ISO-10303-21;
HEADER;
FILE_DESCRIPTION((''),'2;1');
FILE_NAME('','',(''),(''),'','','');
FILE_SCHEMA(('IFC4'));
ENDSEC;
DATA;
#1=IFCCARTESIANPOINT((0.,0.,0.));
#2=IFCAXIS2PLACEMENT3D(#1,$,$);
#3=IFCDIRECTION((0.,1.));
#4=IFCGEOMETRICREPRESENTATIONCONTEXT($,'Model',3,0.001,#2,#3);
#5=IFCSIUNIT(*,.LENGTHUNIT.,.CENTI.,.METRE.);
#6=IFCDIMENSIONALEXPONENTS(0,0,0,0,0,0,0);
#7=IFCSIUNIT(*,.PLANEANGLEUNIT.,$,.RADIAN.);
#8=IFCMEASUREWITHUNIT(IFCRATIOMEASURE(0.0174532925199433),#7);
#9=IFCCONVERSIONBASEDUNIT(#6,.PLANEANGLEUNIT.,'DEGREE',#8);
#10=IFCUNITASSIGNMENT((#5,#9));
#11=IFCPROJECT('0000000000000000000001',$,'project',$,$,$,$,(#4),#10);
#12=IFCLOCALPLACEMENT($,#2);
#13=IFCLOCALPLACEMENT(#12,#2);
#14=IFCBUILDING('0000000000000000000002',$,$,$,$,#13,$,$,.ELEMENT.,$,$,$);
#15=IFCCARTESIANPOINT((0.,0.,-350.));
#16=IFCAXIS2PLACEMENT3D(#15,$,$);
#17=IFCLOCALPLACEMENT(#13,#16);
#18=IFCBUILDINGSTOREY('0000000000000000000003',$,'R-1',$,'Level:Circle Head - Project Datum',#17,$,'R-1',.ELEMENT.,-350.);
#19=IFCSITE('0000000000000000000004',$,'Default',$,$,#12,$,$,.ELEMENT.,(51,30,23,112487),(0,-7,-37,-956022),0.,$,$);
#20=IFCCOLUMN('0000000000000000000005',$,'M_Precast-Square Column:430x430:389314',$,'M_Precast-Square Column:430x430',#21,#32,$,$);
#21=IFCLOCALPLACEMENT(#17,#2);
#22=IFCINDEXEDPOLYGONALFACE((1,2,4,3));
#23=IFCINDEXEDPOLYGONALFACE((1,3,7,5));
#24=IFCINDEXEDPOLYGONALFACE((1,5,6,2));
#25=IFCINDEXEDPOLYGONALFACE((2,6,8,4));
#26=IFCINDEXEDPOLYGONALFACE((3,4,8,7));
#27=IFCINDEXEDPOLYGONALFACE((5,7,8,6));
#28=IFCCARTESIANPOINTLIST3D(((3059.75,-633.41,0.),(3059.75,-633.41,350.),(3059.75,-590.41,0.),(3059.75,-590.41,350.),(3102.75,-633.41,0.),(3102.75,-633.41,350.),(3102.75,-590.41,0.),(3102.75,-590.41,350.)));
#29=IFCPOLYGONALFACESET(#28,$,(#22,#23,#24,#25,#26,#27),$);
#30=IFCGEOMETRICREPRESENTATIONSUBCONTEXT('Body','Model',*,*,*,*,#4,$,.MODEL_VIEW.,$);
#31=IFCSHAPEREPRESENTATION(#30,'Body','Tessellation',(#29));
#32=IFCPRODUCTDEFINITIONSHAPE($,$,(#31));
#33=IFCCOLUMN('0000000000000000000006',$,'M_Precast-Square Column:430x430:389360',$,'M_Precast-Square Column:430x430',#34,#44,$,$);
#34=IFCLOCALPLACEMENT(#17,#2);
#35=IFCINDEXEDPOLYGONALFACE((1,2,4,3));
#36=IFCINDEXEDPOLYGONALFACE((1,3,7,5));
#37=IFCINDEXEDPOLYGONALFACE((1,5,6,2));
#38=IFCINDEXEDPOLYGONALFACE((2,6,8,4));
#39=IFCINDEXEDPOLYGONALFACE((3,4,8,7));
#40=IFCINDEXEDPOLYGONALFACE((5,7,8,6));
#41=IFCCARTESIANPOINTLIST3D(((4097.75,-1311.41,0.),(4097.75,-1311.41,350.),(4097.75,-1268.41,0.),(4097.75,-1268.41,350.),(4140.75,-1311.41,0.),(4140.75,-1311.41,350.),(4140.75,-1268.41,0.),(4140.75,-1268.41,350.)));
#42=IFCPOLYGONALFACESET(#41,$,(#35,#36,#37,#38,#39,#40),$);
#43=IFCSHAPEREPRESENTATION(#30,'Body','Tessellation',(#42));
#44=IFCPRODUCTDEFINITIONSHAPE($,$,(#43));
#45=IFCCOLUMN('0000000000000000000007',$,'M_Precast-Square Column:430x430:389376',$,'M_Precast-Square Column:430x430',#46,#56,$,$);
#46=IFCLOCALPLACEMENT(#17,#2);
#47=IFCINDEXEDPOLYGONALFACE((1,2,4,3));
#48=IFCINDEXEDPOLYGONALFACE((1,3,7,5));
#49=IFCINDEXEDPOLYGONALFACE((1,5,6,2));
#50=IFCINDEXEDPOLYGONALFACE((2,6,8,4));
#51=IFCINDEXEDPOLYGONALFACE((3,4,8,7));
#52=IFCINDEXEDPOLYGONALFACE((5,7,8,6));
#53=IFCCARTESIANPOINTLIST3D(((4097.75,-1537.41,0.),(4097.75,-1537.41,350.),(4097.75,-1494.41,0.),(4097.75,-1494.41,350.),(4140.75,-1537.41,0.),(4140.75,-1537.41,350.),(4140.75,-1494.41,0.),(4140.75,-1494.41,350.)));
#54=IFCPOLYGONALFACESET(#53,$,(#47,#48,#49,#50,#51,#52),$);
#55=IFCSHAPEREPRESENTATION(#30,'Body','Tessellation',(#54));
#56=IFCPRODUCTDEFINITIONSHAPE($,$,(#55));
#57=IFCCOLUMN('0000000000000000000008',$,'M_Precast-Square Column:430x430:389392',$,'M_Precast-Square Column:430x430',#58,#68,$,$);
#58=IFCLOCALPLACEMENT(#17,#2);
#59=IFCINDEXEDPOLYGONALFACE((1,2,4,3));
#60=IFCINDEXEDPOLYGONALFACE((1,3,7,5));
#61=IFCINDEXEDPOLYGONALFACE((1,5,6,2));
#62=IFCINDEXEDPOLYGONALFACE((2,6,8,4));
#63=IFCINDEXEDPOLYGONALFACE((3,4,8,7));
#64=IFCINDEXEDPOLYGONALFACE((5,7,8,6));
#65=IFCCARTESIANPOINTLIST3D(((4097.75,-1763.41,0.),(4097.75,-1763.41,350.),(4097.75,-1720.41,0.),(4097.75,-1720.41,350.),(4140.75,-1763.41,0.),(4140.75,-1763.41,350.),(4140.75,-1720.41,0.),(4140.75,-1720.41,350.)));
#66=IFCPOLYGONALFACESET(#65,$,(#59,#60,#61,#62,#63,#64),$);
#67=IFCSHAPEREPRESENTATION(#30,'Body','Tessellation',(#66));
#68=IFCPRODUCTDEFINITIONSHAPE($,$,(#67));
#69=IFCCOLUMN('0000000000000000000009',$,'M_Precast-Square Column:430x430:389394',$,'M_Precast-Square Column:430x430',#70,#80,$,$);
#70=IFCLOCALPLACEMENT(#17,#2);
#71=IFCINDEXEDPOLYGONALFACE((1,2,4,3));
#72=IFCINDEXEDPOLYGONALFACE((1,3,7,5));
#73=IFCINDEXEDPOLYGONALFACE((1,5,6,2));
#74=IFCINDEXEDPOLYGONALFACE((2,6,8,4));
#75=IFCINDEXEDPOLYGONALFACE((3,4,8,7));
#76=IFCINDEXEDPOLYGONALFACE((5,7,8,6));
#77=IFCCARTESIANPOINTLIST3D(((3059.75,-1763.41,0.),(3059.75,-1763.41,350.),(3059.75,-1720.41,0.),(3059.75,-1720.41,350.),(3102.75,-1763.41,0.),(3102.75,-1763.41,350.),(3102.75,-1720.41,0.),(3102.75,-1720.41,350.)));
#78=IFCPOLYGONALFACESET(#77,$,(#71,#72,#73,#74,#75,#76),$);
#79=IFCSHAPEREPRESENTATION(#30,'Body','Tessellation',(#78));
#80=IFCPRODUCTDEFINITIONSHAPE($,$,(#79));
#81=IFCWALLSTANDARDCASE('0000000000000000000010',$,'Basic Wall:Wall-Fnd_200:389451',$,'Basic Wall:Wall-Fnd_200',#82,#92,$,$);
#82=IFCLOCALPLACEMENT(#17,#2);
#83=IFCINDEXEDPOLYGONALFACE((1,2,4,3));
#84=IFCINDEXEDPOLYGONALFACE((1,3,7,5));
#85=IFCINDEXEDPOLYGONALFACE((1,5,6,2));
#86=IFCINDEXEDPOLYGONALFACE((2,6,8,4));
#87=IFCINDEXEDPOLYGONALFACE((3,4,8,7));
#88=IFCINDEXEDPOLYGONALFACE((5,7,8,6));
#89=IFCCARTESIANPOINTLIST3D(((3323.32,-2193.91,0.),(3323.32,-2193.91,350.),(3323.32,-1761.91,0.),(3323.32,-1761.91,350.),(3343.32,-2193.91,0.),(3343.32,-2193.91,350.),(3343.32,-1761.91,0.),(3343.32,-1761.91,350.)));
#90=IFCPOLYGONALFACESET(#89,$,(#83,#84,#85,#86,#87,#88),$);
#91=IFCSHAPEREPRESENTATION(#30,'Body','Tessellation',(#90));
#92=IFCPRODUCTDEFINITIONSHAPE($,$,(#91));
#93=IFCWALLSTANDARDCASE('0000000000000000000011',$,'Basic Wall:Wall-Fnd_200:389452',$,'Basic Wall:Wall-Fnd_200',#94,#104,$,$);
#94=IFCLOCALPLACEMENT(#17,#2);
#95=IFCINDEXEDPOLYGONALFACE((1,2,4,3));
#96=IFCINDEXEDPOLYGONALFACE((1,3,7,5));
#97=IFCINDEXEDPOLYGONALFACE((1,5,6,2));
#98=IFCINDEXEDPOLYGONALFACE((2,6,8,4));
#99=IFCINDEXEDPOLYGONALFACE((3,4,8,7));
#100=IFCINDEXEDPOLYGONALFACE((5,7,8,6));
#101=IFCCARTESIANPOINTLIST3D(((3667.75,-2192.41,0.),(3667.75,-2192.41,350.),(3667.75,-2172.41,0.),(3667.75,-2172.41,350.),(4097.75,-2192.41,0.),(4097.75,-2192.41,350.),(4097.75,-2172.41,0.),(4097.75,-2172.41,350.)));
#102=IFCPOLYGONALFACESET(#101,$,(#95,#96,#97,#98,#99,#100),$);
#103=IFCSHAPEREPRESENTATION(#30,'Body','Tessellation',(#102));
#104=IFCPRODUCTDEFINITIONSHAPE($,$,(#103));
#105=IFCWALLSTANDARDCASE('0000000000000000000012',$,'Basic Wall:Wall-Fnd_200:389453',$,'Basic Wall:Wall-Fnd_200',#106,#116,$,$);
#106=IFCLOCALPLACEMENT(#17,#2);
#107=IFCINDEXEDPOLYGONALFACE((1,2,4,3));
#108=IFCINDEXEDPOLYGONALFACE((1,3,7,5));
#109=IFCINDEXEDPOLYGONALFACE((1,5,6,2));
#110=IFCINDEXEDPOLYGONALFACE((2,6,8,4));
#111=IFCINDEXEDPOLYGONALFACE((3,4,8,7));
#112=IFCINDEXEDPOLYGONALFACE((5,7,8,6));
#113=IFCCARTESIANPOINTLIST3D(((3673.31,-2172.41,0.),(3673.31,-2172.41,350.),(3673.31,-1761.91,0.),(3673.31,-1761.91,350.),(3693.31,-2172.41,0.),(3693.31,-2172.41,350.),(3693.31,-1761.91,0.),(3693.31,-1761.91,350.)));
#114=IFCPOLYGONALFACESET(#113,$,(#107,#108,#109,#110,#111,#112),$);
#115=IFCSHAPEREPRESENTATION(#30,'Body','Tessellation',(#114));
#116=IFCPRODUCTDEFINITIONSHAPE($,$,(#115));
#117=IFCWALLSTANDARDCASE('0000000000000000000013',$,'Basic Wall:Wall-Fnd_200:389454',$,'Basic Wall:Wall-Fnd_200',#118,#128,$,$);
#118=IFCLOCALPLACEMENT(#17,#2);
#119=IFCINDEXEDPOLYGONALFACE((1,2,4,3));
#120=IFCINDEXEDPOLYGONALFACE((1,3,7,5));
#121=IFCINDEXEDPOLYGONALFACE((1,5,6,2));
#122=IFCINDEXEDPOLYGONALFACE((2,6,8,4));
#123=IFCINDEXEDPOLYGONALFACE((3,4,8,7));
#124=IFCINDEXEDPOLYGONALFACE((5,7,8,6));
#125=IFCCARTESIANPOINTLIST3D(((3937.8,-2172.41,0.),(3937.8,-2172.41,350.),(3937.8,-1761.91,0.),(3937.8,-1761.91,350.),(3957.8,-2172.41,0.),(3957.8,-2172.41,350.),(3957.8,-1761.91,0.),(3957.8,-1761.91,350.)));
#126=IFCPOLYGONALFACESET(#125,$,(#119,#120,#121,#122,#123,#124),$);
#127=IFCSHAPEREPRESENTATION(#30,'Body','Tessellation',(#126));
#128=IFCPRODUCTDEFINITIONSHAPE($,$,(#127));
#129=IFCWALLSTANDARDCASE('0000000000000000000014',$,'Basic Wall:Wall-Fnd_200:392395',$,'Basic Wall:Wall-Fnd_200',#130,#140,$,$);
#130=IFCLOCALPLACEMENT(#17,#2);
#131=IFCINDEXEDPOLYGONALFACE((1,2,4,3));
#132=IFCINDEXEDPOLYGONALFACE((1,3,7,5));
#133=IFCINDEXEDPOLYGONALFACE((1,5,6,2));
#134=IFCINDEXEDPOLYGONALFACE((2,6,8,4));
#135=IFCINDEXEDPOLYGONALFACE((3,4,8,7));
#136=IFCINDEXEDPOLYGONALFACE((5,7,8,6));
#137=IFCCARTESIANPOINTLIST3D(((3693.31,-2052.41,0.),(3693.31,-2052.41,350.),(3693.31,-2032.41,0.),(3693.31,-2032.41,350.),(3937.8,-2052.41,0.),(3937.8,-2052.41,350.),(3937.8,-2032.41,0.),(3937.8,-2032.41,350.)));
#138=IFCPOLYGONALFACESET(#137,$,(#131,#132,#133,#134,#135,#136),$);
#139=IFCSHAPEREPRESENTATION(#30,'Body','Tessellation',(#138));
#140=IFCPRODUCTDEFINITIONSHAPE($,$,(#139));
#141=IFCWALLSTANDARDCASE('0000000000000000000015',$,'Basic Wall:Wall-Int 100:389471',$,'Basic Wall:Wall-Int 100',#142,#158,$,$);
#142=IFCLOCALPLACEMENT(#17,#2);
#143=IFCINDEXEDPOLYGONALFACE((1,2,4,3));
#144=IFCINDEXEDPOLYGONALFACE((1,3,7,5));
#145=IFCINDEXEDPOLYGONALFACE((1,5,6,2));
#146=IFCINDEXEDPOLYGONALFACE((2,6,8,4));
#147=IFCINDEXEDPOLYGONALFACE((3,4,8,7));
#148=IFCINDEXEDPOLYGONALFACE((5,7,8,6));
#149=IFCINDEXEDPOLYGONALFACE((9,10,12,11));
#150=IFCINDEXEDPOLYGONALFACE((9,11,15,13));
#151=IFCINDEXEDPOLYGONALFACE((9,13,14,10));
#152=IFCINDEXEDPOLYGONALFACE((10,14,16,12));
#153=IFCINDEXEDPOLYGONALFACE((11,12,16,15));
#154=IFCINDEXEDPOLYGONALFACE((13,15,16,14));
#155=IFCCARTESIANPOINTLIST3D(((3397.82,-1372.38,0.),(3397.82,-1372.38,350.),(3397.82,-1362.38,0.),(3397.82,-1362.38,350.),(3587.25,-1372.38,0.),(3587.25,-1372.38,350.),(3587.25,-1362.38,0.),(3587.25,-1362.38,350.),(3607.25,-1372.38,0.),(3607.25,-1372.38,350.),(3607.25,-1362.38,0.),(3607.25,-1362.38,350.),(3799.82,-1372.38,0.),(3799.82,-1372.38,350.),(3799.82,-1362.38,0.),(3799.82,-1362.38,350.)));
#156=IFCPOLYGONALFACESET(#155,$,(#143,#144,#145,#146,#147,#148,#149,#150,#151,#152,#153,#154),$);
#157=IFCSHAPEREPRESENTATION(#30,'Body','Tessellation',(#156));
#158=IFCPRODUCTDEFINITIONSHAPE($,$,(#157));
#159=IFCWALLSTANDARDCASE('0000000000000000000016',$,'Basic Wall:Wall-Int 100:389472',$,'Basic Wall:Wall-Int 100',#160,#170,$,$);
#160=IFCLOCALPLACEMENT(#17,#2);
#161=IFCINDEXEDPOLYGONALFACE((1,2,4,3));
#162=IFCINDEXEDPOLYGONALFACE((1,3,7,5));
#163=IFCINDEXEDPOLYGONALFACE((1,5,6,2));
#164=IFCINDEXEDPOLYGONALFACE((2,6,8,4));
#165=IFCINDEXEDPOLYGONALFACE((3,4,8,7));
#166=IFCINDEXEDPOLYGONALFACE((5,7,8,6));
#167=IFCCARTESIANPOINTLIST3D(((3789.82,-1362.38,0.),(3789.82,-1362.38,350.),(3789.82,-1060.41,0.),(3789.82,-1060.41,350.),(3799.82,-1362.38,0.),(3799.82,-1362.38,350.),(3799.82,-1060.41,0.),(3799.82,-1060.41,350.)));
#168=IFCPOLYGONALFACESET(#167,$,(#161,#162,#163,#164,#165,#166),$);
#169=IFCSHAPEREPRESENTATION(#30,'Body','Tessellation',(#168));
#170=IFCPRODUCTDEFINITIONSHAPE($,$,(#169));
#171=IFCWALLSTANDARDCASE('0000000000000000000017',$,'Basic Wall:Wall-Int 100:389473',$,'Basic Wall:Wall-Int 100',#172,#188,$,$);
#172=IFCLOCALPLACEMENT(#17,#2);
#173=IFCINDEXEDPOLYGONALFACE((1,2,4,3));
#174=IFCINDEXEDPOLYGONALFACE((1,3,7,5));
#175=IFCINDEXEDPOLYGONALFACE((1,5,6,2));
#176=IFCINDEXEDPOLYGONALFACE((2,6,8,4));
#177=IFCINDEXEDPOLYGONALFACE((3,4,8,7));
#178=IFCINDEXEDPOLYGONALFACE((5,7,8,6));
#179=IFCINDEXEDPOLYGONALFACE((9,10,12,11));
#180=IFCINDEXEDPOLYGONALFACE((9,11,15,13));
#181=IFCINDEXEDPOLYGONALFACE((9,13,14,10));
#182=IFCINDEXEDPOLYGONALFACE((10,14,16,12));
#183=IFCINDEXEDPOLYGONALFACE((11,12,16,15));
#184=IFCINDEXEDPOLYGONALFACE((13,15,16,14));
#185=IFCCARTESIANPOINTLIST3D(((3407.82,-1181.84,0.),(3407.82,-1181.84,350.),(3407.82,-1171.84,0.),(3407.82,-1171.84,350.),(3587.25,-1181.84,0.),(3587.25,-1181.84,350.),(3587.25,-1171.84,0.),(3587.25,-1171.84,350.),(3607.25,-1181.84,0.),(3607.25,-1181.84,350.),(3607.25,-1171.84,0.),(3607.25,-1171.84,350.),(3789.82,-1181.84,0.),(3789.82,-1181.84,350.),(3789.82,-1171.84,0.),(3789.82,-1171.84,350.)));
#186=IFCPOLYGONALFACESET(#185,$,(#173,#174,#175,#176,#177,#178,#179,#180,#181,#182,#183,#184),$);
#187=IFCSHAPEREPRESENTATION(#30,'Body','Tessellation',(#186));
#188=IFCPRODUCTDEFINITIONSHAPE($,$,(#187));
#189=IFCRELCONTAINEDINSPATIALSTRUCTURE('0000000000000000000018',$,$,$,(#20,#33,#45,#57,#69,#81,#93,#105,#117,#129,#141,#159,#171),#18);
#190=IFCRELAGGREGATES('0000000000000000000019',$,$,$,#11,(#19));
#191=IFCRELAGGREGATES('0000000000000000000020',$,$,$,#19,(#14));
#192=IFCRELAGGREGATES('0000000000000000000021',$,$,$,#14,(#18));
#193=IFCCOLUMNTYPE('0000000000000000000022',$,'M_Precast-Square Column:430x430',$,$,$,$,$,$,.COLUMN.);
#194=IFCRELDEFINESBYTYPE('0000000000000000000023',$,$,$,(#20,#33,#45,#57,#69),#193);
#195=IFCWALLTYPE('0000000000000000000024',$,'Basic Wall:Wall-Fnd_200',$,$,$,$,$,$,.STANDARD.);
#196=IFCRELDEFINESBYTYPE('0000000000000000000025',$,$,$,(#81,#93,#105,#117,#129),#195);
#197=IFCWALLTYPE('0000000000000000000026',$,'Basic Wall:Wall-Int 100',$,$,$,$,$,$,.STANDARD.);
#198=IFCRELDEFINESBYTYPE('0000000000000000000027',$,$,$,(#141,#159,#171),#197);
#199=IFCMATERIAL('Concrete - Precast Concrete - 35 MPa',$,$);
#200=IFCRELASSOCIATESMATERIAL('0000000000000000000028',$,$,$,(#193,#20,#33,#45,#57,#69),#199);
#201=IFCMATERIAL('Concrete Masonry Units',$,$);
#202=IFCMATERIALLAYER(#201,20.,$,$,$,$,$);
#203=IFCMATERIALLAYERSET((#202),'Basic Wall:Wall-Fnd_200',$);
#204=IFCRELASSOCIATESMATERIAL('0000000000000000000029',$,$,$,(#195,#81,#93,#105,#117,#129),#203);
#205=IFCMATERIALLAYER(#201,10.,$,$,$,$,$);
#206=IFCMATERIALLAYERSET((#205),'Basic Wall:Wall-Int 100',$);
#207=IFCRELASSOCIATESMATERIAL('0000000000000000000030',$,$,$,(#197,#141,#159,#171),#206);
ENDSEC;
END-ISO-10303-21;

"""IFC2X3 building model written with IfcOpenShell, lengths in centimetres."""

from ifc_helpers import new_model, entity, si_unit, converted_unit, direction, frame, frame_2d, origin, origin_2d_with_axis, place, context, subcontext, project, spatial, rectangle, extrude, source, transform, mapped, material, layer, layer_set, layer_usage, type_object, type_shapes, element, save


model = new_model("IFC2X3")

# Units and contexts
model_context = context("Model", 3, precision=0.001, world=origin(), true_north=direction((0.0, 1.0)))
body_context = subcontext(model_context, "Body", "Model", "MODEL_VIEW")
ifc_project = project(units=[si_unit("LENGTHUNIT", "METRE", prefix="CENTI"), converted_unit("PLANEANGLEUNIT", "DEGREE", entity("IfcRatioMeasure", 0.0174532925199433), si_unit("PLANEANGLEUNIT", "RADIAN"), dimensions=[0, 0, 0, 0, 0, 0, 0])], contexts=[model_context])

# Site, building, storey
site_placement = place(None, origin())
site = spatial("IfcSite", under=ifc_project, at=site_placement, Name="Default", CompositionType="ELEMENT", RefLatitude=(51, 30, 23, 112487), RefLongitude=(0, -7, -37, -956022), RefElevation=0.0)
building_placement = place(site_placement, origin())
building = spatial("IfcBuilding", under=site, at=building_placement, CompositionType="ELEMENT")
storey_placement = place(building_placement, frame((0.0, 0.0, -350.0)))
storey = spatial("IfcBuildingStorey", under=building, at=storey_placement, Name="R-1", ObjectType="Level:Circle Head - Project Datum", LongName="R-1", CompositionType="ELEMENT", Elevation=-350.0)

# Columns
ifc_material_1 = material(Name="Concrete - Precast Concrete - 35 MPa")
column_type_1 = type_object("IfcColumnType", Name="M_Precast-Square Column:430x430", PredefinedType="COLUMN", material=ifc_material_1)
shared_shape_1 = source(origin(), body_context, "Body", "SweptSolid", [
    extrude(rectangle(XDim=43.0, YDim=43.0, at=origin_2d_with_axis()), frame((0.0, 0.0, -350.0), z_axis=(0.0, 0.0, 1.0), x_axis=(0.0, -1.0, 0.0)), (0.0, 0.0, 1.0), 350.0),
])
type_shapes(column_type_1, [shared_shape_1])
for number, where, name in (
    (1, (3081.25, -611.91, 350.0), "M_Precast-Square Column:430x430:389314"),
    (2, (4119.25, -1289.91, 350.0), "M_Precast-Square Column:430x430:389360"),
    (3, (4119.25, -1515.91, 350.0), "M_Precast-Square Column:430x430:389376"),
    (4, (4119.25, -1741.91, 350.0), "M_Precast-Square Column:430x430:389392"),
    (5, (3081.25, -1741.91, 350.0), "M_Precast-Square Column:430x430:389394"),
):
    element("IfcColumn", number, at=place(storey_placement, frame(where)), inside=storey, type_object=column_type_1, material=ifc_material_1, Name=name, ObjectType="M_Precast-Square Column:430x430", context=body_context, shape_type="MappedRepresentation", body=[
        mapped(shared_shape_1, transform((0.0, 0.0, 0.0), scale=1.0)),
    ])

# Walls
ifc_material_2 = material(Name="Concrete Masonry Units")
ifc_layer_1 = layer(ifc_material_2, 20.0)
ifc_layer_set_1 = layer_set([ifc_layer_1], Name="Basic Wall:Wall-Fnd_200")
ifc_layer_usage_1 = layer_usage(ifc_layer_set_1, "AXIS2", "POSITIVE", -10.0)
wall_type_1 = type_object("IfcWallType", Name="Basic Wall:Wall-Fnd_200", PredefinedType="STANDARD", material=ifc_layer_set_1)
wall_1_placement = place(storey_placement, frame((3333.32, -2193.91, 0.0), z_axis=(0.0, 0.0, 1.0), x_axis=(0.0, 1.0, 0.0)))
element("IfcWallStandardCase", 6, at=wall_1_placement, inside=storey, type_object=wall_type_1, material=ifc_layer_usage_1, Name="Basic Wall:Wall-Fnd_200:389451", ObjectType="Basic Wall:Wall-Fnd_200", context=body_context, shape_type="SweptSolid", body=[
    extrude(rectangle(XDim=432.0, YDim=20.0, at=frame_2d((216.0, 0.0), x_axis=(-1.0, 0.0))), origin(), (0.0, 0.0, 1.0), 350.0),
])
ifc_layer_usage_2 = layer_usage(ifc_layer_set_1, "AXIS2", "POSITIVE", -10.0)
wall_2_placement = place(storey_placement, frame((4097.75, -2182.41, 0.0), z_axis=(0.0, 0.0, 1.0), x_axis=(-1.0, 0.0, 0.0)))
element("IfcWallStandardCase", 7, at=wall_2_placement, inside=storey, type_object=wall_type_1, material=ifc_layer_usage_2, Name="Basic Wall:Wall-Fnd_200:389452", ObjectType="Basic Wall:Wall-Fnd_200", context=body_context, shape_type="SweptSolid", body=[
    extrude(rectangle(XDim=430.0, YDim=20.0, at=frame_2d((215.0, 0.0), x_axis=(-1.0, 0.0))), origin(), (0.0, 0.0, 1.0), 350.0),
])
ifc_layer_usage_3 = layer_usage(ifc_layer_set_1, "AXIS2", "NEGATIVE", 10.0)
wall_3_placement = place(storey_placement, frame((3683.31, -1761.91, 0.0), z_axis=(0.0, 0.0, 1.0), x_axis=(0.0, -1.0, 0.0)))
element("IfcWallStandardCase", 8, at=wall_3_placement, inside=storey, type_object=wall_type_1, material=ifc_layer_usage_3, Name="Basic Wall:Wall-Fnd_200:389453", ObjectType="Basic Wall:Wall-Fnd_200", context=body_context, shape_type="SweptSolid", body=[
    extrude(rectangle(XDim=410.5, YDim=20.0, at=frame_2d((205.25, 0.0), x_axis=(-1.0, 0.0))), origin(), (0.0, 0.0, 1.0), 350.0),
])
ifc_layer_usage_4 = layer_usage(ifc_layer_set_1, "AXIS2", "NEGATIVE", 10.0)
wall_4_placement = place(storey_placement, frame((3947.8, -1761.91, 0.0), z_axis=(0.0, 0.0, 1.0), x_axis=(0.0, -1.0, 0.0)))
element("IfcWallStandardCase", 9, at=wall_4_placement, inside=storey, type_object=wall_type_1, material=ifc_layer_usage_4, Name="Basic Wall:Wall-Fnd_200:389454", ObjectType="Basic Wall:Wall-Fnd_200", context=body_context, shape_type="SweptSolid", body=[
    extrude(rectangle(XDim=410.5, YDim=20.0, at=frame_2d((205.25, 0.0), x_axis=(-1.0, 0.0))), origin(), (0.0, 0.0, 1.0), 350.0),
])
ifc_layer_usage_5 = layer_usage(ifc_layer_set_1, "AXIS2", "POSITIVE", -10.0)
wall_5_placement = place(storey_placement, frame((3937.8, -2042.41, 0.0), z_axis=(0.0, 0.0, 1.0), x_axis=(-1.0, 0.0, 0.0)))
element("IfcWallStandardCase", 10, at=wall_5_placement, inside=storey, type_object=wall_type_1, material=ifc_layer_usage_5, Name="Basic Wall:Wall-Fnd_200:392395", ObjectType="Basic Wall:Wall-Fnd_200", context=body_context, shape_type="SweptSolid", body=[
    extrude(rectangle(XDim=244.49, YDim=20.0, at=frame_2d((122.25, 0.0), x_axis=(-1.0, 0.0))), origin(), (0.0, 0.0, 1.0), 350.0),
])

# Wall, opening
ifc_layer_2 = layer(ifc_material_2, 10.0)
ifc_layer_set_2 = layer_set([ifc_layer_2], Name="Basic Wall:Wall-Int 100")
ifc_layer_usage_6 = layer_usage(ifc_layer_set_2, "AXIS2", "POSITIVE", -5.0)
wall_type_2 = type_object("IfcWallType", Name="Basic Wall:Wall-Int 100", PredefinedType="STANDARD", material=ifc_layer_set_2)
wall_6_placement = place(storey_placement, frame((3397.82, -1367.38, 0.0)))
wall_6 = element("IfcWallStandardCase", 11, at=wall_6_placement, inside=storey, type_object=wall_type_2, material=ifc_layer_usage_6, Name="Basic Wall:Wall-Int 100:389471", ObjectType="Basic Wall:Wall-Int 100", context=body_context, shape_type="SweptSolid", body=[
    extrude(rectangle(XDim=402.0, YDim=10.0, at=frame_2d((201.0, 0.0), x_axis=(-1.0, 0.0))), origin(), (0.0, 0.0, 1.0), 350.0),
])
opening_1_placement = place(storey_placement, frame((3397.82, -1367.38, 0.0)))
element("IfcOpeningElement", 12, at=opening_1_placement, cuts=wall_6, ObjectType="Opening", context=body_context, shape_type="SweptSolid", body=[
    extrude(rectangle(XDim=350.0, YDim=10.0, at=frame_2d((0.0, 0.0), x_axis=(1.0, 0.0))), frame((189.43, 0.0, 175.0), z_axis=(1.0, 0.0, 0.0), x_axis=(0.0, 0.0, -1.0)), (0.0, 0.0, 1.0), 20.0),
])

# Wall
ifc_layer_usage_7 = layer_usage(ifc_layer_set_2, "AXIS2", "POSITIVE", -5.0)
wall_7_placement = place(storey_placement, frame((3794.82, -1362.38, 0.0), z_axis=(0.0, 0.0, 1.0), x_axis=(0.0, 1.0, 0.0)))
element("IfcWallStandardCase", 13, at=wall_7_placement, inside=storey, type_object=wall_type_2, material=ifc_layer_usage_7, Name="Basic Wall:Wall-Int 100:389472", ObjectType="Basic Wall:Wall-Int 100", context=body_context, shape_type="SweptSolid", body=[
    extrude(rectangle(XDim=301.97, YDim=10.0, at=frame_2d((150.98, 0.0), x_axis=(-1.0, 0.0))), origin(), (0.0, 0.0, 1.0), 350.0),
])

# Wall, opening
ifc_layer_usage_8 = layer_usage(ifc_layer_set_2, "AXIS2", "POSITIVE", -5.0)
wall_8_placement = place(storey_placement, frame((3789.82, -1176.84, 0.0), z_axis=(0.0, 0.0, 1.0), x_axis=(-1.0, 0.0, 0.0)))
wall_8 = element("IfcWallStandardCase", 14, at=wall_8_placement, inside=storey, type_object=wall_type_2, material=ifc_layer_usage_8, Name="Basic Wall:Wall-Int 100:389473", ObjectType="Basic Wall:Wall-Int 100", context=body_context, shape_type="SweptSolid", body=[
    extrude(rectangle(XDim=382.0, YDim=10.0, at=frame_2d((191.0, 0.0), x_axis=(-1.0, 0.0))), origin(), (0.0, 0.0, 1.0), 350.0),
])
opening_2_placement = place(storey_placement, frame((3789.82, -1176.84, 0.0), z_axis=(0.0, 0.0, 1.0), x_axis=(-1.0, 0.0, 0.0)))
element("IfcOpeningElement", 15, at=opening_2_placement, cuts=wall_8, ObjectType="Opening", context=body_context, shape_type="SweptSolid", body=[
    extrude(rectangle(XDim=350.0, YDim=10.0, at=frame_2d((0.0, 0.0), x_axis=(1.0, 0.0))), frame((202.57, 0.0, 175.0), z_axis=(-1.0, 0.0, 0.0), x_axis=(0.0, 0.0, 1.0)), (0.0, 0.0, 1.0), 20.0),
])

save(model, "model.ifc")
